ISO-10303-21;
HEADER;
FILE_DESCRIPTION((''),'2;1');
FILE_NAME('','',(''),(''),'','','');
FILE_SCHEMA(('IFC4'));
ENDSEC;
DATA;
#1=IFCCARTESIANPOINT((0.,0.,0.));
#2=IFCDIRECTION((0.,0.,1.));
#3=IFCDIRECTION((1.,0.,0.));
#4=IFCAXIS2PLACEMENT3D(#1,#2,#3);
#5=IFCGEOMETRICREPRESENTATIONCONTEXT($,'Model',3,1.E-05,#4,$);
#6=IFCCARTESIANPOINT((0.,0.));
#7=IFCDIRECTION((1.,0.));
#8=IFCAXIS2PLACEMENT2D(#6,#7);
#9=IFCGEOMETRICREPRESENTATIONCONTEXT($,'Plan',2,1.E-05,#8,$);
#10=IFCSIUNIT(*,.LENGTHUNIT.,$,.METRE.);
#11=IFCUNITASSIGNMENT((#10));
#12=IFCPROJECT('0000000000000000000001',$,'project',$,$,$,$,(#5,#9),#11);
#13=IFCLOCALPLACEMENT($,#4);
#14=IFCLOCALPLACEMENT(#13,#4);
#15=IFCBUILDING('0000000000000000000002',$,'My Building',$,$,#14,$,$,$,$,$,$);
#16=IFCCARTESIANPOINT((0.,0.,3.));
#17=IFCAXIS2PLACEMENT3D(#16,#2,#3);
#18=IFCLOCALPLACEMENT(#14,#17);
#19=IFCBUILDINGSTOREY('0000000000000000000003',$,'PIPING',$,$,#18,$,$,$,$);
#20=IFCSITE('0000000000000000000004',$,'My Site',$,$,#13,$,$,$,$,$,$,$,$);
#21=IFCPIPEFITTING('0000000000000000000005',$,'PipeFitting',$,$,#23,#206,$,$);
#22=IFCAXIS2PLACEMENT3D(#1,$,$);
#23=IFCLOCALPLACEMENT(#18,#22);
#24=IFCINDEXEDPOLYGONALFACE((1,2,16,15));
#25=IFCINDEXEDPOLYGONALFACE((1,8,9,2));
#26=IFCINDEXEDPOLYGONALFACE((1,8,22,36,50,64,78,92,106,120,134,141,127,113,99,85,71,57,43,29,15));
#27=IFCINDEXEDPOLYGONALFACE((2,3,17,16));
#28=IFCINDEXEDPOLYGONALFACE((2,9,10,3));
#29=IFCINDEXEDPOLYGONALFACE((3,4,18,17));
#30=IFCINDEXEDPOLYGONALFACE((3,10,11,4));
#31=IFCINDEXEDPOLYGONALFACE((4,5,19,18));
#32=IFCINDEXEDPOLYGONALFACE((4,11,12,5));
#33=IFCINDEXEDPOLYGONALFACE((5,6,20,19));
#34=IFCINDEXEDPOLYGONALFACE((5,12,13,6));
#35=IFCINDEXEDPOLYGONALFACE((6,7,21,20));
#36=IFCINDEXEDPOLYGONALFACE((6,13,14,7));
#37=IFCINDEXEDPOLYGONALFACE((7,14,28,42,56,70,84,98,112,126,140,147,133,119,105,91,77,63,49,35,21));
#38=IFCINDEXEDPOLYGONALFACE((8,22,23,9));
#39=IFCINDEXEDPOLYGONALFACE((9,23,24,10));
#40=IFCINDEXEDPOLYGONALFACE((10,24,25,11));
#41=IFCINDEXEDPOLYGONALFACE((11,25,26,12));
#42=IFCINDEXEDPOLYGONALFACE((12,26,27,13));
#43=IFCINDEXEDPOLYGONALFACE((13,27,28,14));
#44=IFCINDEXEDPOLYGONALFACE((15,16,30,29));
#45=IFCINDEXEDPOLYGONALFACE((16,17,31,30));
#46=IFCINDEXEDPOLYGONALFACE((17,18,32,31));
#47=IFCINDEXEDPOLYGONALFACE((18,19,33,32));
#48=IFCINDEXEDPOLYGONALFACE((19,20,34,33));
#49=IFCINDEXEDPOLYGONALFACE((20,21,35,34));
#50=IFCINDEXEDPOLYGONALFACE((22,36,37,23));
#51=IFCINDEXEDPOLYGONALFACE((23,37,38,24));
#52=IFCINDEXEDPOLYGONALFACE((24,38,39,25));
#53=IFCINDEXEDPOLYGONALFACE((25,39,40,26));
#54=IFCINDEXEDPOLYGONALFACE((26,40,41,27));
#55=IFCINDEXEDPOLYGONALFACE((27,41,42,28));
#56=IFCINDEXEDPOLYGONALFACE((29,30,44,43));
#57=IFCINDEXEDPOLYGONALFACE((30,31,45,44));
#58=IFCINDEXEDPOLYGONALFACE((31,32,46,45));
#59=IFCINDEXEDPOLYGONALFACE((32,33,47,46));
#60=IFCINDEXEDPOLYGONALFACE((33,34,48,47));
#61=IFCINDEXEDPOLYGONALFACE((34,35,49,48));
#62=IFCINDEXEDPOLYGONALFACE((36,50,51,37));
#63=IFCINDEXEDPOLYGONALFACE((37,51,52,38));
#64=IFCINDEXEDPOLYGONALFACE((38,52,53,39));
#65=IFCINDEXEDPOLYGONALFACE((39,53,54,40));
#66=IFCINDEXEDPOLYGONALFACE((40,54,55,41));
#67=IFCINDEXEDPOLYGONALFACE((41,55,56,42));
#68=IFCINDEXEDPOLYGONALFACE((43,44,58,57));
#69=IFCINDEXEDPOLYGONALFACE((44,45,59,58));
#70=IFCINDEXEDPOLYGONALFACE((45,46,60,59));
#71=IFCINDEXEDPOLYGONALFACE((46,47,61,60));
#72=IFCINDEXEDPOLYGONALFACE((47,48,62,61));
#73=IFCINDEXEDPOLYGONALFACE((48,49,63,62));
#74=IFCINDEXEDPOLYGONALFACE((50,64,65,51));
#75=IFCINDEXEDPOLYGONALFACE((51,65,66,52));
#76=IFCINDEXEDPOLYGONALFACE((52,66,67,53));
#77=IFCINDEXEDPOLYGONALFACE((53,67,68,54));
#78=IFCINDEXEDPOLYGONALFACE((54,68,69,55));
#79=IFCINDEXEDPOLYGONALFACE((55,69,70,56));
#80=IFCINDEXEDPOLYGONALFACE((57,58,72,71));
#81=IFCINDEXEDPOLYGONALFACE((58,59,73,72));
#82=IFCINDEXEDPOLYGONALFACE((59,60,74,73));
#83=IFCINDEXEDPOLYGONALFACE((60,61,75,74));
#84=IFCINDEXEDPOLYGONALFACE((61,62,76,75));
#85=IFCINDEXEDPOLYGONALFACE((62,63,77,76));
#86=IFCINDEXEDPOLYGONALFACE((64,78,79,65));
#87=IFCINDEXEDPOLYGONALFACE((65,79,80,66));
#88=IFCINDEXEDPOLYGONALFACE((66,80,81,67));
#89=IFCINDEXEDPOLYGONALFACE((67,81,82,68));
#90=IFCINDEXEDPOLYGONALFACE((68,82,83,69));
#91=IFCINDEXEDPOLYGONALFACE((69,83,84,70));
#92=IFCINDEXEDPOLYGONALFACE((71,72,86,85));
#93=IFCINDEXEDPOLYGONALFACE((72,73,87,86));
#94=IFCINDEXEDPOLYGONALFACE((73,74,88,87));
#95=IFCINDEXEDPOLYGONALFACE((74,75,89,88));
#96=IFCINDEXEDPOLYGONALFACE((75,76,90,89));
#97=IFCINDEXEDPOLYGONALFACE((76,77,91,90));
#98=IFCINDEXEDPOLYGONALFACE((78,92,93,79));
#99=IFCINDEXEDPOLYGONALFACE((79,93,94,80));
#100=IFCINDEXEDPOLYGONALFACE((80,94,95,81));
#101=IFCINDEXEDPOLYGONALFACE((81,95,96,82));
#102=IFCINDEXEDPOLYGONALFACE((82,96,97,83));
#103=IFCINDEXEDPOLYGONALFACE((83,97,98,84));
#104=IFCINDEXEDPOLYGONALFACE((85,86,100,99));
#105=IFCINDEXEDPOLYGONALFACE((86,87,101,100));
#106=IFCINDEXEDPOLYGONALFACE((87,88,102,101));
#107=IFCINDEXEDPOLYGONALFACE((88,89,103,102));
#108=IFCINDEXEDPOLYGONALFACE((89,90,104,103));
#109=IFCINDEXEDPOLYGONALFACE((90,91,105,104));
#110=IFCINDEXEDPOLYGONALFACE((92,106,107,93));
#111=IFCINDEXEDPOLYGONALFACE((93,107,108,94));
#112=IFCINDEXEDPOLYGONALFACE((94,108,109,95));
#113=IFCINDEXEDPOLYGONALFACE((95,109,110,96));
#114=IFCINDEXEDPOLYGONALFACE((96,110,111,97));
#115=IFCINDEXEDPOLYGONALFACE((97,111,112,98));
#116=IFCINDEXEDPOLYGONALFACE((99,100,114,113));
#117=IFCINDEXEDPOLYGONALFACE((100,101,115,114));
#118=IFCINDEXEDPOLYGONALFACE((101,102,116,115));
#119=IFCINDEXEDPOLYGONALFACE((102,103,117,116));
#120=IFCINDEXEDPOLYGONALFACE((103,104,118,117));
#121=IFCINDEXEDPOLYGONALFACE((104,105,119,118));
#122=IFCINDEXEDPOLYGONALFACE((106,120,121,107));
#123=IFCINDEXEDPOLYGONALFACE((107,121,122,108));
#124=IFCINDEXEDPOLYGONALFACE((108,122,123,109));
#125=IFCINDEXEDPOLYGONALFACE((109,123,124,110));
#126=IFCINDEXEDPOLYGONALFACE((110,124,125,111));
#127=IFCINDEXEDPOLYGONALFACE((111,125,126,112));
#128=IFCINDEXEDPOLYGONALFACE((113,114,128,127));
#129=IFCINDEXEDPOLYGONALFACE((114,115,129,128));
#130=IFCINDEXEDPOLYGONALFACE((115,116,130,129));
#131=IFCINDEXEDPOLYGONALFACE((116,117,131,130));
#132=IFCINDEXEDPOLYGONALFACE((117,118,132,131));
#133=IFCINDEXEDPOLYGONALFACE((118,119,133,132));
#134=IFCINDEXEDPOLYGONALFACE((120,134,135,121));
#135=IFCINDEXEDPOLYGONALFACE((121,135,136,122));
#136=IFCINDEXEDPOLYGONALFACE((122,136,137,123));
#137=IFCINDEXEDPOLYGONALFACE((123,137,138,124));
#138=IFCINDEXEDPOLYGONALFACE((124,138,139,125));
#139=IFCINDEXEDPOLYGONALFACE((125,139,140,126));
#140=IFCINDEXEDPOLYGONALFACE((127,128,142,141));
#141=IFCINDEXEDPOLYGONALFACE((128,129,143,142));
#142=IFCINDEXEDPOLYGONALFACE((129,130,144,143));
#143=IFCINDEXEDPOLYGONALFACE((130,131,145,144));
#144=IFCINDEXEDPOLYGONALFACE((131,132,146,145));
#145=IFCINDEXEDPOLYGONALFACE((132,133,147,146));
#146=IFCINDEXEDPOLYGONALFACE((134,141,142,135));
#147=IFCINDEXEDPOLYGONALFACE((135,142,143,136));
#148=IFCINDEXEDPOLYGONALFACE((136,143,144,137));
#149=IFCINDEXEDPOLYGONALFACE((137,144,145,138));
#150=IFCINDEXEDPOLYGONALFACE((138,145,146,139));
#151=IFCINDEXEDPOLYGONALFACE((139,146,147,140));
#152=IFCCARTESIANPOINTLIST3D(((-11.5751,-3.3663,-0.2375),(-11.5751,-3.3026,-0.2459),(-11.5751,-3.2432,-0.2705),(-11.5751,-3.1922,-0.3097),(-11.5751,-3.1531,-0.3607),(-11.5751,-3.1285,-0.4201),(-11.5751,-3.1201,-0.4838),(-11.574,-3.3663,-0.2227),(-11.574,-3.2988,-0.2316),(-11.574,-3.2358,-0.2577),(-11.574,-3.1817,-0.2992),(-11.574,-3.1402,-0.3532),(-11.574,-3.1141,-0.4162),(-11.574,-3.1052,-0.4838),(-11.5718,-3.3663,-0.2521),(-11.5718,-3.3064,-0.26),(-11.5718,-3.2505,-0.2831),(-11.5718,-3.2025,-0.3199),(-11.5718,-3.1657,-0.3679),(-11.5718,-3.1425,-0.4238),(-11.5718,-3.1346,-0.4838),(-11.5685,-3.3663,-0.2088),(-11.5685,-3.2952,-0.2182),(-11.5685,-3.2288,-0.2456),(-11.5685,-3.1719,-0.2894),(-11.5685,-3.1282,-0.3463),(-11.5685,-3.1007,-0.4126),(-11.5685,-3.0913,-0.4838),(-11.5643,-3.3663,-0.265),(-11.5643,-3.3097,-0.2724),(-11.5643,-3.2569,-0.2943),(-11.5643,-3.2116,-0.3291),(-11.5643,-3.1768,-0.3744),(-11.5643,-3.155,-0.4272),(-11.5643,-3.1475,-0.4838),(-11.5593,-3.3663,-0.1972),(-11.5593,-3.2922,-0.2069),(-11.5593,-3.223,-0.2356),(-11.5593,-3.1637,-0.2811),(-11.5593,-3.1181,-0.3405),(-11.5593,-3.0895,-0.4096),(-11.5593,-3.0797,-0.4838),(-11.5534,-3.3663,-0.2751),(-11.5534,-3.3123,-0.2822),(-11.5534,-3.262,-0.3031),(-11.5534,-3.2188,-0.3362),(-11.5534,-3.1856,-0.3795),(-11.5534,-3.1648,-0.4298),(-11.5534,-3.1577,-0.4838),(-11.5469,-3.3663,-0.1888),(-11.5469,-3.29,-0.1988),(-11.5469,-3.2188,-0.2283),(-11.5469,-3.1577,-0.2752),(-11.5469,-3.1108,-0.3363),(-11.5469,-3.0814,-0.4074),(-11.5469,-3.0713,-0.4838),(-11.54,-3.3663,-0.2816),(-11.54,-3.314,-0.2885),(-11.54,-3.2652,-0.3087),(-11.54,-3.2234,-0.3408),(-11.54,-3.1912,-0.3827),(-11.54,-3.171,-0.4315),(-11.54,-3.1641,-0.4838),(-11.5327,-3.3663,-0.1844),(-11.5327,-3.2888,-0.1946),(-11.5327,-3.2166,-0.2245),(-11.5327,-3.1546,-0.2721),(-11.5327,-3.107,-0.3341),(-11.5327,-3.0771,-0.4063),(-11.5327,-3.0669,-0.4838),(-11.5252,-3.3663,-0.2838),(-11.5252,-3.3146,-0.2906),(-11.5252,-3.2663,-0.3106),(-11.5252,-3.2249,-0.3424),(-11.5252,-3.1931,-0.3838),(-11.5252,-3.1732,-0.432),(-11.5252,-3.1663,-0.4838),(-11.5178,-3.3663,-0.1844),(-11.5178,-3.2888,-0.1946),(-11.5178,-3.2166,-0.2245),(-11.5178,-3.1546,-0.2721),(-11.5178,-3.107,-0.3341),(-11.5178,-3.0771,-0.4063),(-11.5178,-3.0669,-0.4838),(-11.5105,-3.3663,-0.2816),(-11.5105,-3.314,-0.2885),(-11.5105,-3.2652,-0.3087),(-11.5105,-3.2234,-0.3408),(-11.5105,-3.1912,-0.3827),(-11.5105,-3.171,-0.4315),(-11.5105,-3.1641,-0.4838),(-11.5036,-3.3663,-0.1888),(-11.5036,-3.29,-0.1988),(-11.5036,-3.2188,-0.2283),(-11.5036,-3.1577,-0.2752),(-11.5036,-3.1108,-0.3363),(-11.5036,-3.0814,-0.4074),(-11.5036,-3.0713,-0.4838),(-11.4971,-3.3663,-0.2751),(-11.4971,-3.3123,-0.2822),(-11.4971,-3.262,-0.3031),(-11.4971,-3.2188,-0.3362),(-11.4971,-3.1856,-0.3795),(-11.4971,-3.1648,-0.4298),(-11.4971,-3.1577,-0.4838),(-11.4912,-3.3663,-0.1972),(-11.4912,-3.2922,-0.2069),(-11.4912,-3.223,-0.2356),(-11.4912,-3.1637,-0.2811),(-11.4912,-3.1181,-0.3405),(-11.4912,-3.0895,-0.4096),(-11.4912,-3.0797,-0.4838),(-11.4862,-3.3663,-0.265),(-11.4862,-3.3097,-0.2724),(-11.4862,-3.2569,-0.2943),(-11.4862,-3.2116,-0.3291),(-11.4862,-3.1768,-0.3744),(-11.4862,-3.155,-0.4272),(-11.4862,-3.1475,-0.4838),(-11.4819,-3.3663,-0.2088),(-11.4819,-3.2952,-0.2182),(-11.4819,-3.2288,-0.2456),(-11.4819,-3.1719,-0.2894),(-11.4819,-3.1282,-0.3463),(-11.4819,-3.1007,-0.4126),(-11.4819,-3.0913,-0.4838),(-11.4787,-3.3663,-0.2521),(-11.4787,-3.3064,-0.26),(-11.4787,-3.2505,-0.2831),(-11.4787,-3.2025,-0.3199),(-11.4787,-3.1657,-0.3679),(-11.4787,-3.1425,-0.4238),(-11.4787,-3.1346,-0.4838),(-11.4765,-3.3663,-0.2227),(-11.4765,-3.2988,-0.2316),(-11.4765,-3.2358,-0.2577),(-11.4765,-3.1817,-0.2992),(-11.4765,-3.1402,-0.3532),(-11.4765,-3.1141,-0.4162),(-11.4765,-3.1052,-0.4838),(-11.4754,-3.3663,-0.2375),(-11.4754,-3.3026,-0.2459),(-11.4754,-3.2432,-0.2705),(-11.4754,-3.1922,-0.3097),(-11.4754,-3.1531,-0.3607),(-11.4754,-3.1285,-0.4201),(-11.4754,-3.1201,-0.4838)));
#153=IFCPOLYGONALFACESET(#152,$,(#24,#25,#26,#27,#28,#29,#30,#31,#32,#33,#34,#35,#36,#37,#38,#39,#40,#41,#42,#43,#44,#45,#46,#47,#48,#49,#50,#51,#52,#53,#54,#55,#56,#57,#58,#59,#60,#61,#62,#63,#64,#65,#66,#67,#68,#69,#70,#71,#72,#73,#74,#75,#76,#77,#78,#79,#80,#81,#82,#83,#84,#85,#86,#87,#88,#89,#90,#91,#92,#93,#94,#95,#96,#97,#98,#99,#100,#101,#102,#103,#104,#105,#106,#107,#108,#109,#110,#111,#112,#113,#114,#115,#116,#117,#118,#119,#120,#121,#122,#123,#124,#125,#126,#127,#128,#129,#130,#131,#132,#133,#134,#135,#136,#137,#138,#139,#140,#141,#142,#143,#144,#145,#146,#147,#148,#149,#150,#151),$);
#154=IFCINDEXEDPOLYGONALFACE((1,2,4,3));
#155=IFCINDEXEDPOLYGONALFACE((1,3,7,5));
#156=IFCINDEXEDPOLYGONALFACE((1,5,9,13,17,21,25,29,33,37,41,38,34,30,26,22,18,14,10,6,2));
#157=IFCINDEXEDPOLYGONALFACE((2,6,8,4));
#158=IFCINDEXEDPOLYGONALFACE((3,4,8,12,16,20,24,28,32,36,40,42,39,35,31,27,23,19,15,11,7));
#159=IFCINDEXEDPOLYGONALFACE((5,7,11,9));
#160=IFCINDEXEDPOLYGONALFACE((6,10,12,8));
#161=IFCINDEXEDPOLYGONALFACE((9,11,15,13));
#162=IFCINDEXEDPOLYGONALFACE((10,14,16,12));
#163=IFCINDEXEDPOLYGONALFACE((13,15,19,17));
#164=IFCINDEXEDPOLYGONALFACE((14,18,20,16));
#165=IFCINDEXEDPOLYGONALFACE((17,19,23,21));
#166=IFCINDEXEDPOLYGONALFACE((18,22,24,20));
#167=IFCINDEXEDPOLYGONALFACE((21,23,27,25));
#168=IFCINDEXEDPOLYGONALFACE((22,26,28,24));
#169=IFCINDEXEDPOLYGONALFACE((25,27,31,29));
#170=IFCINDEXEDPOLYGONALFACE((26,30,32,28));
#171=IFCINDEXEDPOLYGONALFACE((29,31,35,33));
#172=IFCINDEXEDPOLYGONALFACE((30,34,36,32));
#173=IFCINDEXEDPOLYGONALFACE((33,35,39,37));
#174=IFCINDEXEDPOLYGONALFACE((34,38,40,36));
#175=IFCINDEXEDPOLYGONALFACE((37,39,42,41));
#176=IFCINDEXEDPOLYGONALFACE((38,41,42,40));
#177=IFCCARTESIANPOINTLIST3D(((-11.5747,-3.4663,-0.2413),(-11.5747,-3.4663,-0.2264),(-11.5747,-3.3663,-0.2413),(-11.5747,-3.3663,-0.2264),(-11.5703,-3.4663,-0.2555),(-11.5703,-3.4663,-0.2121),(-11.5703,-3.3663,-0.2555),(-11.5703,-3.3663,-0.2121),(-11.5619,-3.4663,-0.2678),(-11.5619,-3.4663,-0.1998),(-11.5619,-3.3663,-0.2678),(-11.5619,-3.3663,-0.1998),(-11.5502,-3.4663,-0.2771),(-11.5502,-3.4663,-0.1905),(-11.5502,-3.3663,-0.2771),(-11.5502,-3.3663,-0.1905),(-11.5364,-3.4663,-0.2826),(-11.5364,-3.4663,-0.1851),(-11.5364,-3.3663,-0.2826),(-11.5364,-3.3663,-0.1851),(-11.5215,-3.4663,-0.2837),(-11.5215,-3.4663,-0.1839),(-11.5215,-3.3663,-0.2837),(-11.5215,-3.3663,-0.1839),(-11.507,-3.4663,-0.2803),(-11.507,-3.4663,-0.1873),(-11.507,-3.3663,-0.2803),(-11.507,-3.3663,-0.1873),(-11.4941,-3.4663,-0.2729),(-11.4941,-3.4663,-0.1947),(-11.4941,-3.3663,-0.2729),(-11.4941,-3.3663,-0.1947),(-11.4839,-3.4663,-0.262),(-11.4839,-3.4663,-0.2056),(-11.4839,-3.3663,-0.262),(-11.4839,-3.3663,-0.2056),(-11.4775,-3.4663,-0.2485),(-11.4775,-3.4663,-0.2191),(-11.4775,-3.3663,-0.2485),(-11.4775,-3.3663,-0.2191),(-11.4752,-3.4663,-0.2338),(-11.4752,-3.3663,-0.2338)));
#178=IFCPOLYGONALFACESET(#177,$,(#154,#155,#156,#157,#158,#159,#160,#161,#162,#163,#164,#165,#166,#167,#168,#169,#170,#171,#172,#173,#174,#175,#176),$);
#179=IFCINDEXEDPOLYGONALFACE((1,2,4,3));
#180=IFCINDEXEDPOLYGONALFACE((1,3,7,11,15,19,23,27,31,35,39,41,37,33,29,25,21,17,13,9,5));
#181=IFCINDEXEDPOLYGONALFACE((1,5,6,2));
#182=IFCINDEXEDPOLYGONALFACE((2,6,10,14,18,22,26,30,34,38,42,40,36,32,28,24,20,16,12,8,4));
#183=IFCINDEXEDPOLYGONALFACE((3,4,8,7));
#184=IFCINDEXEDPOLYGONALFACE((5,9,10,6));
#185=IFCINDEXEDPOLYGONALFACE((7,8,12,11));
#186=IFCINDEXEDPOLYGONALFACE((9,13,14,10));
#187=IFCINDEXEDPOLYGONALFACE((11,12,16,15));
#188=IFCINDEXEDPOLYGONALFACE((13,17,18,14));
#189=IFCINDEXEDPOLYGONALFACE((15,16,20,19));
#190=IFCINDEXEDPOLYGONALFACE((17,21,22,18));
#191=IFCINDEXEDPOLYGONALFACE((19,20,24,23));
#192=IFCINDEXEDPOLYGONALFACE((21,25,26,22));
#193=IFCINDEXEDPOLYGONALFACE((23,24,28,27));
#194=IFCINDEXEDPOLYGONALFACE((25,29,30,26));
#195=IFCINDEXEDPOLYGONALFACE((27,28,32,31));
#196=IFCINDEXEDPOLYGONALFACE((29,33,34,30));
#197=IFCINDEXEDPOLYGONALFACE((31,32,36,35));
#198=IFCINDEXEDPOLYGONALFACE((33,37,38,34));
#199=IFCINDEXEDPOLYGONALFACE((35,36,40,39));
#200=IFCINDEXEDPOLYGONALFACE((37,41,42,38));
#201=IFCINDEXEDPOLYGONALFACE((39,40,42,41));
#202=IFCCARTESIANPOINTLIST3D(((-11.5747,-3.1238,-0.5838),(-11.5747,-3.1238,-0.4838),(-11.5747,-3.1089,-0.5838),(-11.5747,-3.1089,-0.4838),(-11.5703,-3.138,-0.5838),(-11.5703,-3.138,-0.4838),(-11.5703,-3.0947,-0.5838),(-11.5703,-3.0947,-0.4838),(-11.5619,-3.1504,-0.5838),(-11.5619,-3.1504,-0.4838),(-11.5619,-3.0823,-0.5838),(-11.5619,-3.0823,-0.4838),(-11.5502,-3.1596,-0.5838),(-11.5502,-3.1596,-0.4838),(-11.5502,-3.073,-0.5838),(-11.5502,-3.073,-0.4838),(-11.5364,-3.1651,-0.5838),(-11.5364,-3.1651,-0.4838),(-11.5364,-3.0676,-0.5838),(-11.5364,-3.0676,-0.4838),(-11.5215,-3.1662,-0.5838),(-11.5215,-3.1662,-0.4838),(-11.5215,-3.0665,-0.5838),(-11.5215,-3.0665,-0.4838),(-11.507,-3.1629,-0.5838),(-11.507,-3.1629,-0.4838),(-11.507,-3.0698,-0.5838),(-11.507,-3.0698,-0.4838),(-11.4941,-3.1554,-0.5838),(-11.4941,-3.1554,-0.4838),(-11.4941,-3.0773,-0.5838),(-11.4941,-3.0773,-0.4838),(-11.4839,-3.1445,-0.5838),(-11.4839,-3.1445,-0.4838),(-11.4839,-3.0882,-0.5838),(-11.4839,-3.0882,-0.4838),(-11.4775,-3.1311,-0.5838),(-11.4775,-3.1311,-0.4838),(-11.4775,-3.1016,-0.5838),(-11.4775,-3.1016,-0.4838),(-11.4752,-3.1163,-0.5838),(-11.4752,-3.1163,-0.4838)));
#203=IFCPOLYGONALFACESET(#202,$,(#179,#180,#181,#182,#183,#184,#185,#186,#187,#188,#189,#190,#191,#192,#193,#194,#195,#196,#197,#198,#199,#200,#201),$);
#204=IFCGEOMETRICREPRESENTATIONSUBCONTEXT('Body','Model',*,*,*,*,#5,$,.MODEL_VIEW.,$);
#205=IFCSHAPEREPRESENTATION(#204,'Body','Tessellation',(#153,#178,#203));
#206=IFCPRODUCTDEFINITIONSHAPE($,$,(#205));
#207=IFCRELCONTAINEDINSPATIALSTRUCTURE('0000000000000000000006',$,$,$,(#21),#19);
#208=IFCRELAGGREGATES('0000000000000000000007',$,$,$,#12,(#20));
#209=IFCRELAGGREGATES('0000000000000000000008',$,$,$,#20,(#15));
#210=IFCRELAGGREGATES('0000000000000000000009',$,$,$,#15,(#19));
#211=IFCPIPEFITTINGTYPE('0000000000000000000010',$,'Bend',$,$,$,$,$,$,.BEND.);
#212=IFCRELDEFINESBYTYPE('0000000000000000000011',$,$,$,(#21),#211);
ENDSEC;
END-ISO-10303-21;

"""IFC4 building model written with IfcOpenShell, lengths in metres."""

from ifc_helpers import new_model, entity, si_unit, frame, origin_with_axes, origin_2d_with_axis, place, context, subcontext, project, spatial, circle, extrude, source, transform, mapped, type_object, type_shapes, element, save


model = new_model("IFC4")

# Units and contexts
model_context = context("Model", 3, precision=1e-05, world=origin_with_axes())
plan_context = context("Plan", 2, precision=1e-05, world=origin_2d_with_axis())
body_context = subcontext(model_context, "Body", "Model", "MODEL_VIEW")
ifc_project = project(units=[si_unit("LENGTHUNIT", "METRE")], contexts=[model_context, plan_context])

# Site, building, storey
site_placement = place(None, origin_with_axes())
site = spatial("IfcSite", under=ifc_project, at=site_placement, Name="My Site")
building_placement = place(site_placement, origin_with_axes())
building = spatial("IfcBuilding", under=site, at=building_placement, Name="My Building")
storey_placement = place(building_placement, frame((0.0, 0.0, 3.0), z_axis=(0.0, 0.0, 1.0), x_axis=(1.0, 0.0, 0.0)))
storey = spatial("IfcBuildingStorey", under=building, at=storey_placement, Name="PIPING")

# Pipe fitting
pipe_fitting_type = type_object("IfcPipeFittingType", Name="Bend", PredefinedType="BEND")
shared_shape = source(origin_with_axes(), body_context, "Body", "SolidModel", [
    entity("IfcSweptDiskSolid", entity("IfcIndexedPolyCurve", entity("IfcCartesianPointList3D", [[0.0, 0.0, -0.1], [0.0, -0.0732, -0.2768], [0.0, -0.25, -0.35]]), [entity("IfcArcIndex", [1, 2, 3])]), 0.05),
    extrude(circle(Radius=0.05), origin_with_axes(), (0.0, 0.0, -1.0), 0.1),
    extrude(circle(Radius=0.05), frame((0.0, -0.25, -0.35), z_axis=(0.0, -1.0, 0.0), x_axis=(1.0, 0.0, 0.0)), (0.0, 0.0, 1.0), 0.1),
])
type_shapes(pipe_fitting_type, [shared_shape])
for number, where, z_axis, x_axis, name in (
    (1, (-11.5252, -3.4663, -0.2338), (0.0, -1.0, 0.0), (1.0, 0.0, 0.0), "PipeFitting"),
):
    element("IfcPipeFitting", number, at=place(storey_placement, frame(where, z_axis=z_axis, x_axis=x_axis)), inside=storey, type_object=pipe_fitting_type, Name=name, context=body_context, shape_type="MappedRepresentation", body=[
        mapped(shared_shape, transform((0.0, 0.0, 0.0), x_axis=(1.0, 0.0, 0.0), y_axis=(0.0, 1.0, 0.0), z_axis=(0.0, 0.0, 1.0), scale=1.0)),
    ])

save(model, "model.ifc")
